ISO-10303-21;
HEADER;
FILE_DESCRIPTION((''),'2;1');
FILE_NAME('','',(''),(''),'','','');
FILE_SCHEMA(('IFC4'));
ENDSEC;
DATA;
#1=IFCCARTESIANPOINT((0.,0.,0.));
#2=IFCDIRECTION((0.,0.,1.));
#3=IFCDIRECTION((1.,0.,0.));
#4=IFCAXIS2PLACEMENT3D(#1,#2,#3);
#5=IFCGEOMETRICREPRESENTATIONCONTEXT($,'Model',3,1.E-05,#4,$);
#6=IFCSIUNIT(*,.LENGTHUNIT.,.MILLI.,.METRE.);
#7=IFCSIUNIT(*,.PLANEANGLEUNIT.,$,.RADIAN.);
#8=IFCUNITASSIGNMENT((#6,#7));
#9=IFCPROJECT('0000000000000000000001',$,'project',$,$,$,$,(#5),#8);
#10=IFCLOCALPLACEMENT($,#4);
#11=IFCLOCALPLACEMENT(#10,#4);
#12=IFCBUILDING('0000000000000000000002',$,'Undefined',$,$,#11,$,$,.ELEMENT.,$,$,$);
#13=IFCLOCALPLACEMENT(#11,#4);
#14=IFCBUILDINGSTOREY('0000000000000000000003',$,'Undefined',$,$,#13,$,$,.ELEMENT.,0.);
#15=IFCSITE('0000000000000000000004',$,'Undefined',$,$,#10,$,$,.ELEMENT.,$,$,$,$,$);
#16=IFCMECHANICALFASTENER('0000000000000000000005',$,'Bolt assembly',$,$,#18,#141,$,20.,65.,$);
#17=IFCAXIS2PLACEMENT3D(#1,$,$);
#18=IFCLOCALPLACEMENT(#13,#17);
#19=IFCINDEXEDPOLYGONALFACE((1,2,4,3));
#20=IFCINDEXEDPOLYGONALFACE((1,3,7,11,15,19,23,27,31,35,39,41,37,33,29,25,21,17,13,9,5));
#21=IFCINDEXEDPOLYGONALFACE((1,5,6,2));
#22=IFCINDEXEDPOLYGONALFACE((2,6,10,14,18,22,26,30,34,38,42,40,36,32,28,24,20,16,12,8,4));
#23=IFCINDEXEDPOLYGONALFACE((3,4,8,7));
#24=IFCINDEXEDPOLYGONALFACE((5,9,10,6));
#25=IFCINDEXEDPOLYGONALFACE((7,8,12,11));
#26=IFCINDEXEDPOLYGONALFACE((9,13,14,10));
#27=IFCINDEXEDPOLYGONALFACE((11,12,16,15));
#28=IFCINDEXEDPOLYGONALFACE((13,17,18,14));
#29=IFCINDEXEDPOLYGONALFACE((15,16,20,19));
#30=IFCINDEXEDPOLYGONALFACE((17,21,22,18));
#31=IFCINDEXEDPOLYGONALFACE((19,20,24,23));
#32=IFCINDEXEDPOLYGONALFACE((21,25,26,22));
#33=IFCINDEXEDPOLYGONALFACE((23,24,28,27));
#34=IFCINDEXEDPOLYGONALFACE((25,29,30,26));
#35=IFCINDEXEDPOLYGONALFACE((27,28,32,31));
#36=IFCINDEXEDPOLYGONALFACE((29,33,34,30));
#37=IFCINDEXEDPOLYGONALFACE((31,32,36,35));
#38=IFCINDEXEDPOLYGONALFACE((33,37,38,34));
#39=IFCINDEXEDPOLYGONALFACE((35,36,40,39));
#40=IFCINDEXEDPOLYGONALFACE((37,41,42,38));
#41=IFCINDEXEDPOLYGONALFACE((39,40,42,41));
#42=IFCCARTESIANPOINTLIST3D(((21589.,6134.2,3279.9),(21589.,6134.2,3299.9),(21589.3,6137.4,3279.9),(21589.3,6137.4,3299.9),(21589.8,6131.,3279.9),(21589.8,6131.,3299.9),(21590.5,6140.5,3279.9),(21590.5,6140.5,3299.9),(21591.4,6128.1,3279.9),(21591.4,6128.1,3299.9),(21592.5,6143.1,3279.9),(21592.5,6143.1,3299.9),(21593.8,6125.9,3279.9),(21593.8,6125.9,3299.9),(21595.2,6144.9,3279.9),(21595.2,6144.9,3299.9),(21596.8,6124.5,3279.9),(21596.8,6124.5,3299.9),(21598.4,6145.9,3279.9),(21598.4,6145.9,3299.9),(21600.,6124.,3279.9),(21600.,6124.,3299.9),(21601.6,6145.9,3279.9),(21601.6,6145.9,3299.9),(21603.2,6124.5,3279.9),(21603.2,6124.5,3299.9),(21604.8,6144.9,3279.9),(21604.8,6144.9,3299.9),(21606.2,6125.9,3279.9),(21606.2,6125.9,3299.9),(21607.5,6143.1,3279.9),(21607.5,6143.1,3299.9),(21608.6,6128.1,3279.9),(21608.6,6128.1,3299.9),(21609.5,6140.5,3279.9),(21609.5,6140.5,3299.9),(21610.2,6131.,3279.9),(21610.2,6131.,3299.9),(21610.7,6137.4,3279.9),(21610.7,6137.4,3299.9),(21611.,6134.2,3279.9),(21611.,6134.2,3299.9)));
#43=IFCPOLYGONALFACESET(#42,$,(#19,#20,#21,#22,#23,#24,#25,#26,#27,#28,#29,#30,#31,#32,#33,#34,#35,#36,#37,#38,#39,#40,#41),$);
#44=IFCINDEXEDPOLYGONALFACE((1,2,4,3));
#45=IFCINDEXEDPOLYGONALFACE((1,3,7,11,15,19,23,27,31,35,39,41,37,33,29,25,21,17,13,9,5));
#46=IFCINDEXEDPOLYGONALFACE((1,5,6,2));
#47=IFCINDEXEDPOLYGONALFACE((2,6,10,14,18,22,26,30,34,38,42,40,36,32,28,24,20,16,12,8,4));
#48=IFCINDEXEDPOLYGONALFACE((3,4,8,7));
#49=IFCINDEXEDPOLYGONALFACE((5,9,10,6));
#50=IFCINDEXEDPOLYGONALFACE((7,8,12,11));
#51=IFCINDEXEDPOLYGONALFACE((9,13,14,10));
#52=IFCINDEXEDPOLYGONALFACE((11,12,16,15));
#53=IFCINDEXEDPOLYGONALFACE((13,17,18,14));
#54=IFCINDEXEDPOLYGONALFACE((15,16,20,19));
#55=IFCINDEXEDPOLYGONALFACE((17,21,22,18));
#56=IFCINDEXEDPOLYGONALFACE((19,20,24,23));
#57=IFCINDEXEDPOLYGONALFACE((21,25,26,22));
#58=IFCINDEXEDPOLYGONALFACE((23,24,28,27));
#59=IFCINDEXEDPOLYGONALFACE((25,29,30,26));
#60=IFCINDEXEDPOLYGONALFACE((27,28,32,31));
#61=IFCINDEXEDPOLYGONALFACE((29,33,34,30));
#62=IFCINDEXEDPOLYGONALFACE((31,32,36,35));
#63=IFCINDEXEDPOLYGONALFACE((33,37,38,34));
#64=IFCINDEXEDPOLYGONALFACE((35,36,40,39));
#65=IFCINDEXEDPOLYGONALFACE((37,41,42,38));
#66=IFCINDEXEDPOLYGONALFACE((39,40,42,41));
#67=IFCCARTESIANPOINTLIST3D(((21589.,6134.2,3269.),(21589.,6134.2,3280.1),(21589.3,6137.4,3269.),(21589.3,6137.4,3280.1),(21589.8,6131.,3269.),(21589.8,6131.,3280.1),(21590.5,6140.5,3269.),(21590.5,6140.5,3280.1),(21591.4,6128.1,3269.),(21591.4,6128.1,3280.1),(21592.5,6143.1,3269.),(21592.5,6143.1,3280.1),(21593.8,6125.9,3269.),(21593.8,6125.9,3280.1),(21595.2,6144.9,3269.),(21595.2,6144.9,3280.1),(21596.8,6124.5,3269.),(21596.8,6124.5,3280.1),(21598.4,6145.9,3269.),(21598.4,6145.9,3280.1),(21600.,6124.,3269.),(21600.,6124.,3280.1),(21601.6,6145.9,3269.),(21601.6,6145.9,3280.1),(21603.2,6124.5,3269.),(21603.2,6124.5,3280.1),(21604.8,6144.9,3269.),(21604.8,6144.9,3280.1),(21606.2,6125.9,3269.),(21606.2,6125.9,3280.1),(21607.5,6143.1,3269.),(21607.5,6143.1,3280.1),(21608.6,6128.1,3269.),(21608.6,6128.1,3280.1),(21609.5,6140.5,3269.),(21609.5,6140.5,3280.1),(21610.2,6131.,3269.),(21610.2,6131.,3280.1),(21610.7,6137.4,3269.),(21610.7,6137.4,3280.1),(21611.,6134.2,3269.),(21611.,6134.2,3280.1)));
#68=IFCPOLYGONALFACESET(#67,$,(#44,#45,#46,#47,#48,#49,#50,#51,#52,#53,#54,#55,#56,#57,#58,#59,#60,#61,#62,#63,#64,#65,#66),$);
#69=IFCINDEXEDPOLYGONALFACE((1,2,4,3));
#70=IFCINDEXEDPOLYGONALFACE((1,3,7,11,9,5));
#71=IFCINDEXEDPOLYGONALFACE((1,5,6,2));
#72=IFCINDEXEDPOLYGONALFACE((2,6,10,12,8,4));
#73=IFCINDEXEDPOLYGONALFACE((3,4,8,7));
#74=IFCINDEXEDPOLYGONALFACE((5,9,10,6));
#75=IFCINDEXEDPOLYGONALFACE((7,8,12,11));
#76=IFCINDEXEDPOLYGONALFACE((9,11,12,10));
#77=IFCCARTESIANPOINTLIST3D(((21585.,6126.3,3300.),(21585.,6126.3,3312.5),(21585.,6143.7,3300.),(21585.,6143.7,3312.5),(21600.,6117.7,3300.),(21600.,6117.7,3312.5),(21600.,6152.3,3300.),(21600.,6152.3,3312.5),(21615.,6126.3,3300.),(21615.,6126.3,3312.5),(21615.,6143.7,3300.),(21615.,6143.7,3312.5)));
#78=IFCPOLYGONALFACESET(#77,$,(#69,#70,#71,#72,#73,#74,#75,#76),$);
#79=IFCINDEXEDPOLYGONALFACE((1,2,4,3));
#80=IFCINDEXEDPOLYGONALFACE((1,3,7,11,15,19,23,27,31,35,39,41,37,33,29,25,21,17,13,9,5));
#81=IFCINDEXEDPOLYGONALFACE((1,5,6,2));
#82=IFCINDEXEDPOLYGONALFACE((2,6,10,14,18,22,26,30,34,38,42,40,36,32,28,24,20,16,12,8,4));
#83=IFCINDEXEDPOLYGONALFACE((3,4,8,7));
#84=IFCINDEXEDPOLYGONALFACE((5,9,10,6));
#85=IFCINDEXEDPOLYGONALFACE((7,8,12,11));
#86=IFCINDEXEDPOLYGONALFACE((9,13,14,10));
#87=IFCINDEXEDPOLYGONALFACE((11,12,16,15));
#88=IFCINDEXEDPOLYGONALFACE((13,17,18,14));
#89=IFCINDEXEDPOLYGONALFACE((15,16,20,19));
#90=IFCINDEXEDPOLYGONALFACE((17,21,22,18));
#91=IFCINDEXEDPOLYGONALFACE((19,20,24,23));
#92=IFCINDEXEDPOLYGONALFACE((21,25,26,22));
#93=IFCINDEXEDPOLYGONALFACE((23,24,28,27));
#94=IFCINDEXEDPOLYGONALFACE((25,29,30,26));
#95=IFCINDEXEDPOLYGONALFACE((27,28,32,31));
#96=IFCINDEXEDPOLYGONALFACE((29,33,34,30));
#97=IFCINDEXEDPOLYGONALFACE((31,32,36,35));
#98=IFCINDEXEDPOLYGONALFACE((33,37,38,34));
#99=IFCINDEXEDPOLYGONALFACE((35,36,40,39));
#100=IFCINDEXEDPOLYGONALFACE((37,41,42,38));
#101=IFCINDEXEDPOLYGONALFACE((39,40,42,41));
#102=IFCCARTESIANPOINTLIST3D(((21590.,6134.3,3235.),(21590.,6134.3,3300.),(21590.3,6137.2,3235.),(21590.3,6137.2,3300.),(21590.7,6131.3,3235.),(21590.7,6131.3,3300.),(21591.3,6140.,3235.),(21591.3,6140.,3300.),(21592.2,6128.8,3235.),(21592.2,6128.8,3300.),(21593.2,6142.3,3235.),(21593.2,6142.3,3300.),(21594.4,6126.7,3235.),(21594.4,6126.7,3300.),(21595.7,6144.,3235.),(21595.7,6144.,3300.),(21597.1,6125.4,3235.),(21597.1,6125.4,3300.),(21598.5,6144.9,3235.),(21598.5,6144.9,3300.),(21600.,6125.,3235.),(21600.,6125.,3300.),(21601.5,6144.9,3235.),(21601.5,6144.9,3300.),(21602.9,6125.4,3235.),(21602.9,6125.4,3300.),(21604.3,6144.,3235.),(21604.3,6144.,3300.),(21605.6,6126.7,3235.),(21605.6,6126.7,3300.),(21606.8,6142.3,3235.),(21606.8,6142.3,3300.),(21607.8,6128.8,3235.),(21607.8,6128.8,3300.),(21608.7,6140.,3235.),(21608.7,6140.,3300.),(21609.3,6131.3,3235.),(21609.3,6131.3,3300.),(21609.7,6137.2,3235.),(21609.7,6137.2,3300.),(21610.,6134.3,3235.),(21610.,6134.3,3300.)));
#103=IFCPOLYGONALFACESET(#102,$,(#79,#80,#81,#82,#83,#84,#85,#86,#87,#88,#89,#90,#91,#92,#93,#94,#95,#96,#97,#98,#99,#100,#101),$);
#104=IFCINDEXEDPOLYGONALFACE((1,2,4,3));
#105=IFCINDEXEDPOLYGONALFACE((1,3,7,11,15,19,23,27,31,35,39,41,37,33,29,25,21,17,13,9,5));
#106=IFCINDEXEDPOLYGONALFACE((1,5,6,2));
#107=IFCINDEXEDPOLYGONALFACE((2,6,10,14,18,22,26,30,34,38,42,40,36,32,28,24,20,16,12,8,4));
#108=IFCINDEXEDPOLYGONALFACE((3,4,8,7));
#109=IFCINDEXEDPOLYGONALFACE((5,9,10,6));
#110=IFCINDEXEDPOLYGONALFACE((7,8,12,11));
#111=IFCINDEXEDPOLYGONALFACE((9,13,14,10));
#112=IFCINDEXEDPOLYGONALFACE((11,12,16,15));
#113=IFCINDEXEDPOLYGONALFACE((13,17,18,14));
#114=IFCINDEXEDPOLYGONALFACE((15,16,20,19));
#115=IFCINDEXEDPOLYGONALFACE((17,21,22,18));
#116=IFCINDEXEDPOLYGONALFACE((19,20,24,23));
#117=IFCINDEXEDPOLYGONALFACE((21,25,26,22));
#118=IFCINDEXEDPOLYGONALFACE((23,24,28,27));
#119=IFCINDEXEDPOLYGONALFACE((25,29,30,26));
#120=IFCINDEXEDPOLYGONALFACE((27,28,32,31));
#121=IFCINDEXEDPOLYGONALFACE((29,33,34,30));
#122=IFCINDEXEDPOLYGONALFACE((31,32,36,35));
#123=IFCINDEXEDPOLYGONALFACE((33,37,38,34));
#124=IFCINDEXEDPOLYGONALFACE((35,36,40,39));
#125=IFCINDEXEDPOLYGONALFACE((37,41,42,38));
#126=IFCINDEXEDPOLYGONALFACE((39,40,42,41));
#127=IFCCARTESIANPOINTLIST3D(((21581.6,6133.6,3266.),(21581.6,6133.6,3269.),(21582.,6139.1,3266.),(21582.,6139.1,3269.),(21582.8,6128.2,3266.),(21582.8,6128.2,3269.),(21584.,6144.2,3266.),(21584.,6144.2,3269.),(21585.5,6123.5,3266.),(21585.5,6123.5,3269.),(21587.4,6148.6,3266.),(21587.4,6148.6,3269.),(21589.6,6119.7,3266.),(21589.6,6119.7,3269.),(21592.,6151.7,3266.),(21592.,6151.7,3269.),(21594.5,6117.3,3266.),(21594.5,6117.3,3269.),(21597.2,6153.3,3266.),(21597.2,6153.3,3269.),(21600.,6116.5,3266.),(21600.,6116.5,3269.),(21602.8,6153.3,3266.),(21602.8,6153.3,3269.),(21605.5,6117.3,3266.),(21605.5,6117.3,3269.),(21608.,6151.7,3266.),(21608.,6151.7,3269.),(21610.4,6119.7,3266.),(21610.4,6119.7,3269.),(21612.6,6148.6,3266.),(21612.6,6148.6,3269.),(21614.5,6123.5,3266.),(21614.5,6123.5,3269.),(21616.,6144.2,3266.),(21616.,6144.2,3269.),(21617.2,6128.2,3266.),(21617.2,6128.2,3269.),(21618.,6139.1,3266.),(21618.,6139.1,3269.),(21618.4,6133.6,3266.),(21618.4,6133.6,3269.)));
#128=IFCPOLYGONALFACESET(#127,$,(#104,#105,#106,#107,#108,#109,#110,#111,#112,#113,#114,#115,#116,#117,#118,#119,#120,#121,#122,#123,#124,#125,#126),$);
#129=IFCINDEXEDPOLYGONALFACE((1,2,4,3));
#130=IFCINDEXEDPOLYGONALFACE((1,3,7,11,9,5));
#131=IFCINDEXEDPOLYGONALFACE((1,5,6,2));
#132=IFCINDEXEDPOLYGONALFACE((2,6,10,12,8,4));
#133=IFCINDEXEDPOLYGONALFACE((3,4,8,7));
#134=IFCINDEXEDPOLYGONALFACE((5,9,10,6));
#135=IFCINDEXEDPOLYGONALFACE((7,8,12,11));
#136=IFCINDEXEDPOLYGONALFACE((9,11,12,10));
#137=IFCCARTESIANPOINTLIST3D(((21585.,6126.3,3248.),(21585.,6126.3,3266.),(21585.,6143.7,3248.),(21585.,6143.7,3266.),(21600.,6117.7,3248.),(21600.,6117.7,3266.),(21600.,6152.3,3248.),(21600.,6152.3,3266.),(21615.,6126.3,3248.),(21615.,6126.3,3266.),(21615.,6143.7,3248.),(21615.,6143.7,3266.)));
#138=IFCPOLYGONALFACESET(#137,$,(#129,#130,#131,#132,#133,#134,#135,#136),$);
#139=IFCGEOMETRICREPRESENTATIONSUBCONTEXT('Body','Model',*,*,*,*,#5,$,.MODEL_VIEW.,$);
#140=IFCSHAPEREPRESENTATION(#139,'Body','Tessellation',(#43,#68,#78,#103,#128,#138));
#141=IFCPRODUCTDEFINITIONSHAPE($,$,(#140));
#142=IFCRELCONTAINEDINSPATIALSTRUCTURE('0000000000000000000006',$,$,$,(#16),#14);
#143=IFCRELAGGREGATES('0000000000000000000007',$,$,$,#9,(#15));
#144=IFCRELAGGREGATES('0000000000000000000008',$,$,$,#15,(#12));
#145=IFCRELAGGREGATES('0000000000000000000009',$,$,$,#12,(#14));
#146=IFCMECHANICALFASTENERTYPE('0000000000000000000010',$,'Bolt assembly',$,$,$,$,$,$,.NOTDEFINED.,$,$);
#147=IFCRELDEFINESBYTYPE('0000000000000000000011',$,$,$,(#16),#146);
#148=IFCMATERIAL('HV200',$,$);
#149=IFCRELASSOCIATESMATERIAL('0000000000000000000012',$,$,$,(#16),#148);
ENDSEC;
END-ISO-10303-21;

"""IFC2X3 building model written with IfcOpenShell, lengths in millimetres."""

from ifc_helpers import new_model, si_unit, frame, origin_with_axes, origin_2d_with_axis, place, context, subcontext, project, spatial, polyline, circle, outline, extrude, source, transform, mapped, material, type_object, element, save


model = new_model("IFC2X3")

# Units and contexts
model_context = context("Model", 3, precision=1e-05, world=origin_with_axes())
body_context = subcontext(model_context, "Body", "Model", "MODEL_VIEW")
ifc_project = project(units=[si_unit("LENGTHUNIT", "METRE", prefix="MILLI"), si_unit("PLANEANGLEUNIT", "RADIAN")], contexts=[model_context])

# Site, building, storey
site_placement = place(None, origin_with_axes())
site = spatial("IfcSite", under=ifc_project, at=site_placement, Name="Undefined", CompositionType="ELEMENT")
building_placement = place(site_placement, origin_with_axes())
building = spatial("IfcBuilding", under=site, at=building_placement, Name="Undefined", CompositionType="ELEMENT")
storey_placement = place(building_placement, origin_with_axes())
storey = spatial("IfcBuildingStorey", under=building, at=storey_placement, Name="Undefined", CompositionType="ELEMENT", Elevation=0.0)

# Mechanical fastener
ifc_material_1 = material(Name="HV200")
mechanical_fastener_type = type_object("IfcMechanicalFastenerType", Name="Bolt assembly")
shared_shape_1 = source(origin_with_axes(), body_context, "Body", "SweptSolid", [
    extrude(circle(Radius=11.0, at=origin_2d_with_axis()), frame((0.0, -19.9, 0.0), z_axis=(0.0, 1.0, 0.0), x_axis=(1.0, 0.0, 0.0)), (0.0, 0.0, 1.0), 20.0),
    extrude(circle(Radius=11.0, at=origin_2d_with_axis()), frame((0.0, -0.1, 0.0), z_axis=(0.0, 1.0, 0.0), x_axis=(1.0, 0.0, 0.0)), (0.0, 0.0, 1.0), 11.1),
    extrude(outline(polyline([(17.3, 0.0), (8.7, 15.0), (-8.7, 15.0), (-17.3, 0.0), (-8.7, -15.0), (8.7, -15.0), (17.3, 0.0)])), frame((0.0, -32.5, 0.0), z_axis=(0.0, 1.0, 0.0), x_axis=(1.0, 0.0, 0.0)), (0.0, 0.0, 1.0), 12.5),
    extrude(circle(Radius=10.0, at=origin_2d_with_axis()), frame((0.0, -20.0, 0.0), z_axis=(0.0, 1.0, 0.0), x_axis=(1.0, 0.0, 0.0)), (0.0, 0.0, 1.0), 65.0),
    extrude(circle(Radius=18.5, at=origin_2d_with_axis()), frame((0.0, 11.0, 0.0), z_axis=(0.0, 1.0, 0.0), x_axis=(1.0, 0.0, 0.0)), (0.0, 0.0, 1.0), 3.0),
    extrude(outline(polyline([(17.3, 0.0), (8.7, 15.0), (-8.7, 15.0), (-17.3, 0.0), (-8.7, -15.0), (8.7, -15.0), (17.3, 0.0)])), frame((0.0, 14.0, 0.0), z_axis=(0.0, 1.0, 0.0), x_axis=(1.0, 0.0, 0.0)), (0.0, 0.0, 1.0), 18.0),
])
for number, where, z_axis, x_axis, name in (
    (1, (21600.0, 6135.0, 3280.0), (1.0, 0.0, 0.0), (0.0, -1.0, 0.0), "Bolt assembly"),
):
    element("IfcMechanicalFastener", number, at=place(storey_placement, frame(where, z_axis=z_axis, x_axis=x_axis)), inside=storey, type_object=mechanical_fastener_type, material=ifc_material_1, Name=name, NominalDiameter=20.0, NominalLength=65.0, context=body_context, shape_type="MappedRepresentation", body=[
        mapped(shared_shape_1, transform((0.0, 0.0, 0.0))),
    ])

save(model, "model.ifc")
